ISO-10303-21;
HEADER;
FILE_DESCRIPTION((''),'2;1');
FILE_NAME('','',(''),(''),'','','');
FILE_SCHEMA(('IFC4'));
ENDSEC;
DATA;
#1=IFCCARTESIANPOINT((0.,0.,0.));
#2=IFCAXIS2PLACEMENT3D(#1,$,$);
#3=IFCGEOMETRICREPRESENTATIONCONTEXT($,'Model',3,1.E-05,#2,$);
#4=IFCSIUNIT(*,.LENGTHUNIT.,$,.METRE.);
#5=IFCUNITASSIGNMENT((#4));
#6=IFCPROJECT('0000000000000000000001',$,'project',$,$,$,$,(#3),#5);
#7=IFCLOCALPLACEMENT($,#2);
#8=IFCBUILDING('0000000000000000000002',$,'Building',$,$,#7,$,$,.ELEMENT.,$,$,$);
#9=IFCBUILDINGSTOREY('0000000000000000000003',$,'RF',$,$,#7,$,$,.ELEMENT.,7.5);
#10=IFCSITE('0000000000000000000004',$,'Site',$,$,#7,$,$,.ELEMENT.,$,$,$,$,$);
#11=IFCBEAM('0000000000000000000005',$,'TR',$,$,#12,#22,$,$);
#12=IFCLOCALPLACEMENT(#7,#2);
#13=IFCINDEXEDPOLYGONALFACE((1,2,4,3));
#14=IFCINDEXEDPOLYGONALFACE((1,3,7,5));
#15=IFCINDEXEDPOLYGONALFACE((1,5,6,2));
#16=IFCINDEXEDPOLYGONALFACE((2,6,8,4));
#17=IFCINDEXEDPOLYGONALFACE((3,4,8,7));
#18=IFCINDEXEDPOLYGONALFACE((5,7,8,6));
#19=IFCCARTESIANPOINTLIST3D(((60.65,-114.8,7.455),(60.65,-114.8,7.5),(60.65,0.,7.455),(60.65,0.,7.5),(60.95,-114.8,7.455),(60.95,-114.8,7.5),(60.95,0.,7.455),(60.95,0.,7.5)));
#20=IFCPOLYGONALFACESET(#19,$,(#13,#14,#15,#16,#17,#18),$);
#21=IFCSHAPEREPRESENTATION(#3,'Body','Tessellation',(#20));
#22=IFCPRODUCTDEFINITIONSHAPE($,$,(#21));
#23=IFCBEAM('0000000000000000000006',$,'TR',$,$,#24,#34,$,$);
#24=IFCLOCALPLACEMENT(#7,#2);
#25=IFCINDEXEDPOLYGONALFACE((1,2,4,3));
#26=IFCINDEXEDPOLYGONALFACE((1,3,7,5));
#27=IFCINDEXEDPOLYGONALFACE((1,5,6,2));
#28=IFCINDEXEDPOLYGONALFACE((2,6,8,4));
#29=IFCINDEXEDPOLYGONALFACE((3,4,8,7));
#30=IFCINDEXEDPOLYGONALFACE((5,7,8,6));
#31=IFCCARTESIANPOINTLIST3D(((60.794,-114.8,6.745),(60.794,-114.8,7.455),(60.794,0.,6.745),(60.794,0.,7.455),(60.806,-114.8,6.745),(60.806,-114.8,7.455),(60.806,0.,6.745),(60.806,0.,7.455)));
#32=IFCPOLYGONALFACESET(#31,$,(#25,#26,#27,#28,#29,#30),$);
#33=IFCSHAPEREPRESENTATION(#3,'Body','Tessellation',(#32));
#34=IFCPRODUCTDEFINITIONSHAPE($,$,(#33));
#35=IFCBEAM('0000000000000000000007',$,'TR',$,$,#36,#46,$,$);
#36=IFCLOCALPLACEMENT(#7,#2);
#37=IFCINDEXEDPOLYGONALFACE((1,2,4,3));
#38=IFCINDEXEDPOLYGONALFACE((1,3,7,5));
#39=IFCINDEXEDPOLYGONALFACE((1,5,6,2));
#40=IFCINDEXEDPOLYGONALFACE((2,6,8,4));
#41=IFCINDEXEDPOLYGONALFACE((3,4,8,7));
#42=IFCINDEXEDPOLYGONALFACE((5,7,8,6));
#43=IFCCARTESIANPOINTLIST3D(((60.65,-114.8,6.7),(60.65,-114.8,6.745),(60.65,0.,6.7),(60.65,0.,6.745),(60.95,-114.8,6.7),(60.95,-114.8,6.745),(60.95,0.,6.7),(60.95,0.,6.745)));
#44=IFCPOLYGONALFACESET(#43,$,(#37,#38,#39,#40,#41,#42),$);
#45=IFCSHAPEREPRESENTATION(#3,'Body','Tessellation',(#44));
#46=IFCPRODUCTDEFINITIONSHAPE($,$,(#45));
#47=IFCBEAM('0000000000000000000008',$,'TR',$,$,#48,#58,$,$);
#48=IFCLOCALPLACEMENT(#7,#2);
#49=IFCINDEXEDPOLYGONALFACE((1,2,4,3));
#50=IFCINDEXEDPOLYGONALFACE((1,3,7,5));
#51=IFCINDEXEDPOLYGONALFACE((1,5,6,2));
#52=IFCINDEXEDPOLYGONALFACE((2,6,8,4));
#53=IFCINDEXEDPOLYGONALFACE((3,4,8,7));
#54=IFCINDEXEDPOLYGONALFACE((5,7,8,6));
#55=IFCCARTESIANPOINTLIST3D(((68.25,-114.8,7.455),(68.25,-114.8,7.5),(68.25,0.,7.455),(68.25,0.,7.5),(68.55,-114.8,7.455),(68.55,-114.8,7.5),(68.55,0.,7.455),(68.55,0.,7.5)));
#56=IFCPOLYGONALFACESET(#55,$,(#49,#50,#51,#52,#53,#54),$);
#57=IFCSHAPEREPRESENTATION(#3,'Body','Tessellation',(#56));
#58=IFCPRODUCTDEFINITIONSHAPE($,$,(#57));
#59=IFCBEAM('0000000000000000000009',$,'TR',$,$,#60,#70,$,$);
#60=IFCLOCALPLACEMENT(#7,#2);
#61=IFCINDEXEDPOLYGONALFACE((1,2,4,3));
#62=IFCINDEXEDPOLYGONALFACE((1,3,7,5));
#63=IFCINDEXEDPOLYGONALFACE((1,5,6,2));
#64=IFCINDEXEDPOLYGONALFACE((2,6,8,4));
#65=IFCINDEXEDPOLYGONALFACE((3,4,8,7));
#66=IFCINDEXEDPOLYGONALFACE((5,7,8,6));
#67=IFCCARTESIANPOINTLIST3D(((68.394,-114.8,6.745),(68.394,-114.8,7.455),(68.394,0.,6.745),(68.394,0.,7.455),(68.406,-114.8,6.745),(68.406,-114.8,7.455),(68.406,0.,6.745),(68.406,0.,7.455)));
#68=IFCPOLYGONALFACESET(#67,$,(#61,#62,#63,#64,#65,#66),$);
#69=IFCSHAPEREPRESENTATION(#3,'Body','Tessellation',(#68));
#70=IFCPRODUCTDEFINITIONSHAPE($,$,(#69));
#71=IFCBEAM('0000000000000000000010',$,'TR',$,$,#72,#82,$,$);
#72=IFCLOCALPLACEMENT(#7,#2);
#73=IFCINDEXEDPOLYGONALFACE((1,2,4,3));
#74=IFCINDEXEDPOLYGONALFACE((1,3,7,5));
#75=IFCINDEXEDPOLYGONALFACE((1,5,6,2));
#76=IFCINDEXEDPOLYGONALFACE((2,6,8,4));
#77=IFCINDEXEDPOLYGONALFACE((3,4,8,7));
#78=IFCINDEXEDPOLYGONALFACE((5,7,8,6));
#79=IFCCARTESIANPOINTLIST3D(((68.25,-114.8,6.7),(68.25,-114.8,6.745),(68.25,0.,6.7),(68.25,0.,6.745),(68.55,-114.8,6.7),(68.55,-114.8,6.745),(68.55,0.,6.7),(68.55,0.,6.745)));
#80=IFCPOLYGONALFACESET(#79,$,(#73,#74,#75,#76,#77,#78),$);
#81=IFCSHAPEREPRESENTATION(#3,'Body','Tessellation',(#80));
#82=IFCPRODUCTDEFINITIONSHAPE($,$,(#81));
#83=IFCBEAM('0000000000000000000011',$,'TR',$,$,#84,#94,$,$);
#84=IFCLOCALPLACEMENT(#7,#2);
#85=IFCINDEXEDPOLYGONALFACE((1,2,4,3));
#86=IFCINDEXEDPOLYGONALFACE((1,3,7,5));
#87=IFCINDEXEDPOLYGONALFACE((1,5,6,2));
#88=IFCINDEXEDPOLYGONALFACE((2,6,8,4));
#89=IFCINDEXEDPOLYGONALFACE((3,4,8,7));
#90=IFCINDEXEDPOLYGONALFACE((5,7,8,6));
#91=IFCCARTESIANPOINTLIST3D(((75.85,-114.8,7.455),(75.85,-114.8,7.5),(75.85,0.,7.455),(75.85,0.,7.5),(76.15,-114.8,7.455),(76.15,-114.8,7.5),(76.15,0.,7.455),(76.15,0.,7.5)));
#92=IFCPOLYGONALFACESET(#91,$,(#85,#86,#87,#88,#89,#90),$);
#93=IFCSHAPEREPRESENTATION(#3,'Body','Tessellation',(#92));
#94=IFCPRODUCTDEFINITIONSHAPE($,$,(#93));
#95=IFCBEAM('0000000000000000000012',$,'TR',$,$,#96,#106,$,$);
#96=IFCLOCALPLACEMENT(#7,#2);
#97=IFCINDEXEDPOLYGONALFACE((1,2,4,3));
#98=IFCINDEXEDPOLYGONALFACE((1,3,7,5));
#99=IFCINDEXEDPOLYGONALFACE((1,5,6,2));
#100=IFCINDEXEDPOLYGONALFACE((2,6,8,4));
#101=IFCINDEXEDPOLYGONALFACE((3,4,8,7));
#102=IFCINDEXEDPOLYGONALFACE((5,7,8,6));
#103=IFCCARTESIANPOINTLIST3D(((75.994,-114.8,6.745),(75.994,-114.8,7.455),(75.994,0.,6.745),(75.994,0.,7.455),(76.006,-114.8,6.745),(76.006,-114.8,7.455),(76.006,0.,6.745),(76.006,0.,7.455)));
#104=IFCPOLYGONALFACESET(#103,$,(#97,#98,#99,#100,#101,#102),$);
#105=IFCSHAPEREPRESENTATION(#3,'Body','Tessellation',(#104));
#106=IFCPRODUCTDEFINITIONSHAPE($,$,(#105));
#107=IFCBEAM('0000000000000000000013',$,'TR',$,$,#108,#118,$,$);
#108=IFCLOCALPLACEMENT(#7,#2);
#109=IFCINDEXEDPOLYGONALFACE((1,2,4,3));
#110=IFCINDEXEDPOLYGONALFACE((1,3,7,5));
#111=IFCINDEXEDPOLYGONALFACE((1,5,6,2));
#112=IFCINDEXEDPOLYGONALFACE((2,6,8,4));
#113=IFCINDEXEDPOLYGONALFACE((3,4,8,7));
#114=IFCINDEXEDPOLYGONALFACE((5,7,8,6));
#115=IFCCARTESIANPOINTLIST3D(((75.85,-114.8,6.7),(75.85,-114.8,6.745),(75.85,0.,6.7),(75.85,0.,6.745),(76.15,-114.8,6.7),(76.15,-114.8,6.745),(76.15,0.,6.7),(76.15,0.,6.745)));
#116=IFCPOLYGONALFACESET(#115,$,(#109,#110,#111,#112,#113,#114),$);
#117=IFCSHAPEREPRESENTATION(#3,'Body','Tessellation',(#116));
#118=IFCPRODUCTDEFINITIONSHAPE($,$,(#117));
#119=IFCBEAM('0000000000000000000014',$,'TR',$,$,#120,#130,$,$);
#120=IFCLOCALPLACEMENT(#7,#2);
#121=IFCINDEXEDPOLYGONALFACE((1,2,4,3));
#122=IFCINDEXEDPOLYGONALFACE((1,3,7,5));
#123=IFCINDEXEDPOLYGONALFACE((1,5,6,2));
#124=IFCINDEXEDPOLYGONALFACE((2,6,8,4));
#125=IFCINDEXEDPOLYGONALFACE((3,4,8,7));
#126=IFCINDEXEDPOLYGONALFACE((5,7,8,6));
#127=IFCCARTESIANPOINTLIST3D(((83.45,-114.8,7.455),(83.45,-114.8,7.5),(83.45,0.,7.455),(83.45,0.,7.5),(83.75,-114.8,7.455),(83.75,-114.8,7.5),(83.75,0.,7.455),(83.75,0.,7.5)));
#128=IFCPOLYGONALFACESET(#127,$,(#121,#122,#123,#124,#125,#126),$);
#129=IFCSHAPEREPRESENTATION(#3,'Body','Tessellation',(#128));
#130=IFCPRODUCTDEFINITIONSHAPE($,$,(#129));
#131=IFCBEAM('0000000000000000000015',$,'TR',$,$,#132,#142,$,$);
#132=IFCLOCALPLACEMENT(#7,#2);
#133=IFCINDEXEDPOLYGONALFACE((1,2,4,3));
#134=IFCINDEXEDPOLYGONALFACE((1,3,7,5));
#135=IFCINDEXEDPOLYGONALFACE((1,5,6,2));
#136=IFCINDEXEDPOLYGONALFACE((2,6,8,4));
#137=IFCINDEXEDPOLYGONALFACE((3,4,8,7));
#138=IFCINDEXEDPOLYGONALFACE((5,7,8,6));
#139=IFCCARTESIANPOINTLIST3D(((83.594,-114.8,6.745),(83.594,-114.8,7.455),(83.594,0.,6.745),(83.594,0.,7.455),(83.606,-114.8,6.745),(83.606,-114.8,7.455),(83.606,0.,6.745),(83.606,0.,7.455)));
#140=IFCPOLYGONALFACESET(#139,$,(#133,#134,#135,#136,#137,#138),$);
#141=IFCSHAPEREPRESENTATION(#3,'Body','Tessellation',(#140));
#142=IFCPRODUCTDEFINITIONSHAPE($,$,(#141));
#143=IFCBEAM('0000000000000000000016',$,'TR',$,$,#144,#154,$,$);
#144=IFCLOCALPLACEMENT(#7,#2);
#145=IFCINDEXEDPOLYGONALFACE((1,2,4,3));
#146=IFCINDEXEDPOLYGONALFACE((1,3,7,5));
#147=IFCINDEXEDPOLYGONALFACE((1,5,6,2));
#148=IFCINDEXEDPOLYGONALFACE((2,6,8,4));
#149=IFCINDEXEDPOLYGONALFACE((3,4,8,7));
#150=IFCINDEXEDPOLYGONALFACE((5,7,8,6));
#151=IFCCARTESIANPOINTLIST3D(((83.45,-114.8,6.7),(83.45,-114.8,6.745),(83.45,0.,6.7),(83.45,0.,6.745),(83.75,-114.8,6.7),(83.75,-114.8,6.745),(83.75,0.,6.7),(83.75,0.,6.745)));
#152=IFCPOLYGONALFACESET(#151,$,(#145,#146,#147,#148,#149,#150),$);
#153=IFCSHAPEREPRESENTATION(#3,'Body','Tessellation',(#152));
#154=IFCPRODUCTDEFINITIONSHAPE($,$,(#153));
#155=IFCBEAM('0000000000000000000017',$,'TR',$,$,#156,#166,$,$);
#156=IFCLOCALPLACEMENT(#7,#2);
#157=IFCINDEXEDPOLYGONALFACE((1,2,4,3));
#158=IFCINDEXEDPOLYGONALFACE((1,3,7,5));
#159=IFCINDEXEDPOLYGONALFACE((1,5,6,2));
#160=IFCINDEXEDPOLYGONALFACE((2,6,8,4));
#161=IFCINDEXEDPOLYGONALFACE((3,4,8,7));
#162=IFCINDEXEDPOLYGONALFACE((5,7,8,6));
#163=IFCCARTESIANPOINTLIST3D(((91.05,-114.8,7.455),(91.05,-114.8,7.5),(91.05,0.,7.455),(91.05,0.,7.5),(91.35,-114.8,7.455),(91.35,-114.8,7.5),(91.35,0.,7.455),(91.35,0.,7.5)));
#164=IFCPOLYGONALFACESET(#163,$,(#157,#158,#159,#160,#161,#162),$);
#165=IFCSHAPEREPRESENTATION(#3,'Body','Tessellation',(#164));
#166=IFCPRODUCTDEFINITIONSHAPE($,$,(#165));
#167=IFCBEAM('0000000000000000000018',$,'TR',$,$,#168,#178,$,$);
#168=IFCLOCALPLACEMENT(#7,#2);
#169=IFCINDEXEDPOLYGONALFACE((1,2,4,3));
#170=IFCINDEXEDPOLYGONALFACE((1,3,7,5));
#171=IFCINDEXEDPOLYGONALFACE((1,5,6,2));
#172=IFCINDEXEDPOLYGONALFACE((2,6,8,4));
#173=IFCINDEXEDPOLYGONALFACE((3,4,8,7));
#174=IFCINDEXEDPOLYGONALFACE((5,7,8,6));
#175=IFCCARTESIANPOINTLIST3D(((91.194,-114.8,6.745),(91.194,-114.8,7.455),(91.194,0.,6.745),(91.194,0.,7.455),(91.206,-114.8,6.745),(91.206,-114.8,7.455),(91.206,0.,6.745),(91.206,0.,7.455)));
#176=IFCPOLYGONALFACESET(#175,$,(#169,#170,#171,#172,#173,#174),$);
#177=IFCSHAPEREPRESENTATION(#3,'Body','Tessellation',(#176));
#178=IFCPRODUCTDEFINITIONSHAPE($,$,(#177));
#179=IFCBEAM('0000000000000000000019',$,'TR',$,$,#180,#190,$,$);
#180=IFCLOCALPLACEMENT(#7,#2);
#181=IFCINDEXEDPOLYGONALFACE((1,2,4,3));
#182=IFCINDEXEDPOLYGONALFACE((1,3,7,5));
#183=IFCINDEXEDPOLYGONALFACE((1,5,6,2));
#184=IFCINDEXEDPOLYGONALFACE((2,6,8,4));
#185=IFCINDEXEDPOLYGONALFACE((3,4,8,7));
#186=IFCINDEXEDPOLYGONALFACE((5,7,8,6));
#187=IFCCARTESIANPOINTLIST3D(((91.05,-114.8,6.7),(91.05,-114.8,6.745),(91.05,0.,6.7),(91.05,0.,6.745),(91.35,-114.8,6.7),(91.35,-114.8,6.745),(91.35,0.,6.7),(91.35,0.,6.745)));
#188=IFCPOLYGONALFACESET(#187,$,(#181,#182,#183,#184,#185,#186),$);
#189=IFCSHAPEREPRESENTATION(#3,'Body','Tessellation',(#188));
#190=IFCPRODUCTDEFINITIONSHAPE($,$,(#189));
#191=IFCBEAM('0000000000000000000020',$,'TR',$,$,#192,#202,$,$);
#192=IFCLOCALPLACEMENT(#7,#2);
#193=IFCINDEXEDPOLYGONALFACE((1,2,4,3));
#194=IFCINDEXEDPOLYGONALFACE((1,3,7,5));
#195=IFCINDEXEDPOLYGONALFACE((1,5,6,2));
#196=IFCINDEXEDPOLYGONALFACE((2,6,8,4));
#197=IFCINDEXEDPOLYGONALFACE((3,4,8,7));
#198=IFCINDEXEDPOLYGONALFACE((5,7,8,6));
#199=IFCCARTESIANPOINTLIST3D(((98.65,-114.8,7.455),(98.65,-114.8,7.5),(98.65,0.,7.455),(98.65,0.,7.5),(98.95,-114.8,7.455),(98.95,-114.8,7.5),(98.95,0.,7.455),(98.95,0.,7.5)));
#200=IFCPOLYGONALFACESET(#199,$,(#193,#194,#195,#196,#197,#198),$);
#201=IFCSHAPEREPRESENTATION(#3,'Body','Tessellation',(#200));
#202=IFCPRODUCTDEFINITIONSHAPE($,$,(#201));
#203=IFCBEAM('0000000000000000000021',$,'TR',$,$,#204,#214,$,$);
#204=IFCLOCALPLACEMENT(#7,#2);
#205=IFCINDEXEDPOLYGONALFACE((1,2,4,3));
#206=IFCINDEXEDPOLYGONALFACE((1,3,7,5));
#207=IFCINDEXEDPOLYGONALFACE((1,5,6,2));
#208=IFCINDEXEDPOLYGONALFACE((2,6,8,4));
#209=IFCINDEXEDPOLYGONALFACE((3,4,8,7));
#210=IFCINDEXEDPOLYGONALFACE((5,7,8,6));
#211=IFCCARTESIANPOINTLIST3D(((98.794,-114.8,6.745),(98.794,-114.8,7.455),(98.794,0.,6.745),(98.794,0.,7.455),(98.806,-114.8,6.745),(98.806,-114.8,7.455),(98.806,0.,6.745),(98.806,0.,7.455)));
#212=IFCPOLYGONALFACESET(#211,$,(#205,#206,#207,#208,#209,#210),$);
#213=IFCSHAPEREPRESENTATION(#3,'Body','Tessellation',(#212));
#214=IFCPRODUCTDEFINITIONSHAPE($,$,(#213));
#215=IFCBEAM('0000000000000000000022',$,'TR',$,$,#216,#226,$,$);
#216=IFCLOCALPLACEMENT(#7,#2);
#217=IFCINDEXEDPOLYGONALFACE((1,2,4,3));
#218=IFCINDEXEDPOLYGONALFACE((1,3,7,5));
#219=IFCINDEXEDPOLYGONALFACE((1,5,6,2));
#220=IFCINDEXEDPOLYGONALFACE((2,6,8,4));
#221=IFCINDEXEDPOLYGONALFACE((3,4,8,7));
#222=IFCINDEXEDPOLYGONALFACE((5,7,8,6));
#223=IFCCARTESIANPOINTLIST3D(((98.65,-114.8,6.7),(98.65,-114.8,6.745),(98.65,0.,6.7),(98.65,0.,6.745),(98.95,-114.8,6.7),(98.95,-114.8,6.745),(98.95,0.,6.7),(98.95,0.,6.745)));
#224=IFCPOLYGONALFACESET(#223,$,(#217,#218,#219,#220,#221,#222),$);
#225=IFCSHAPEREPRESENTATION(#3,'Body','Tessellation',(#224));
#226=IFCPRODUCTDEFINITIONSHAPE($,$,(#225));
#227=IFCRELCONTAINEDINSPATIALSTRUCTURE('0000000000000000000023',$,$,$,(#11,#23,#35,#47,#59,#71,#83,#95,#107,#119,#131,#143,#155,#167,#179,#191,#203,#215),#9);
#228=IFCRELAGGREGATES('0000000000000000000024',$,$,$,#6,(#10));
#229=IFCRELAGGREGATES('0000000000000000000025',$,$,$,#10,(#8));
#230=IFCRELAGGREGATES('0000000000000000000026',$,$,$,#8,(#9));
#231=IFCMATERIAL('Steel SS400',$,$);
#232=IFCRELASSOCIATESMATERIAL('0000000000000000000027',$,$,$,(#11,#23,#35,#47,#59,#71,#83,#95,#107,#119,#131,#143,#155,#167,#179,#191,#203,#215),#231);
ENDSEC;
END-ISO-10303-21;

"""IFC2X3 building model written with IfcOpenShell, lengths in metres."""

from ifc_helpers import new_model, si_unit, frame, origin, origin_2d, place, context, project, spatial, rectangle, extrude, material, element, save


model = new_model("IFC2X3")

# Units and contexts
model_context = context("Model", 3, precision=1e-05, world=origin())
ifc_project = project(units=[si_unit("LENGTHUNIT", "METRE")], contexts=[model_context])

# Site, building, storey
placement = place(None, origin())
site = spatial("IfcSite", under=ifc_project, at=placement, Name="Site", CompositionType="ELEMENT")
building = spatial("IfcBuilding", under=site, at=placement, Name="Building", CompositionType="ELEMENT")
storey = spatial("IfcBuildingStorey", under=building, at=placement, Name="RF", CompositionType="ELEMENT", Elevation=7.5)

# Beams
ifc_material = material(Name="Steel SS400")
beam_1_placement = place(None, frame((60.8, -57.4, 7.455)))
element("IfcBeam", 1, at=beam_1_placement, inside=storey, material=ifc_material, Name="TR", context=model_context, shape_type="SweptSolid", body=[
    extrude(rectangle(XDim=0.3, YDim=114.8, at=origin_2d()), origin(), (0.0, 0.0, 1.0), 0.045),
])
beam_2_placement = place(None, frame((60.8, -57.4, 6.745)))
element("IfcBeam", 2, at=beam_2_placement, inside=storey, material=ifc_material, Name="TR", context=model_context, shape_type="SweptSolid", body=[
    extrude(rectangle(XDim=0.012, YDim=114.8, at=origin_2d()), origin(), (0.0, 0.0, 1.0), 0.71),
])
for number, where, name in (
    (3, (60.8, -57.4, 6.7), "TR"),
    (4, (68.4, -57.4, 7.455), "TR"),
):
    element("IfcBeam", number, at=place(None, frame(where)), inside=storey, material=ifc_material, Name=name, context=model_context, shape_type="SweptSolid", body=[
        extrude(rectangle(XDim=0.3, YDim=114.8, at=origin_2d()), origin(), (0.0, 0.0, 1.0), 0.045),
    ])
beam_3_placement = place(None, frame((68.4, -57.4, 6.745)))
element("IfcBeam", 5, at=beam_3_placement, inside=storey, material=ifc_material, Name="TR", context=model_context, shape_type="SweptSolid", body=[
    extrude(rectangle(XDim=0.012, YDim=114.8, at=origin_2d()), origin(), (0.0, 0.0, 1.0), 0.71),
])
for number, where, name in (
    (6, (68.4, -57.4, 6.7), "TR"),
    (7, (76.0, -57.4, 7.455), "TR"),
):
    element("IfcBeam", number, at=place(None, frame(where)), inside=storey, material=ifc_material, Name=name, context=model_context, shape_type="SweptSolid", body=[
        extrude(rectangle(XDim=0.3, YDim=114.8, at=origin_2d()), origin(), (0.0, 0.0, 1.0), 0.045),
    ])
beam_4_placement = place(None, frame((76.0, -57.4, 6.745)))
element("IfcBeam", 8, at=beam_4_placement, inside=storey, material=ifc_material, Name="TR", context=model_context, shape_type="SweptSolid", body=[
    extrude(rectangle(XDim=0.012, YDim=114.8, at=origin_2d()), origin(), (0.0, 0.0, 1.0), 0.71),
])
for number, where, name in (
    (9, (76.0, -57.4, 6.7), "TR"),
    (10, (83.6, -57.4, 7.455), "TR"),
):
    element("IfcBeam", number, at=place(None, frame(where)), inside=storey, material=ifc_material, Name=name, context=model_context, shape_type="SweptSolid", body=[
        extrude(rectangle(XDim=0.3, YDim=114.8, at=origin_2d()), origin(), (0.0, 0.0, 1.0), 0.045),
    ])
beam_5_placement = place(None, frame((83.6, -57.4, 6.745)))
element("IfcBeam", 11, at=beam_5_placement, inside=storey, material=ifc_material, Name="TR", context=model_context, shape_type="SweptSolid", body=[
    extrude(rectangle(XDim=0.012, YDim=114.8, at=origin_2d()), origin(), (0.0, 0.0, 1.0), 0.71),
])
for number, where, name in (
    (12, (83.6, -57.4, 6.7), "TR"),
    (13, (91.2, -57.4, 7.455), "TR"),
):
    element("IfcBeam", number, at=place(None, frame(where)), inside=storey, material=ifc_material, Name=name, context=model_context, shape_type="SweptSolid", body=[
        extrude(rectangle(XDim=0.3, YDim=114.8, at=origin_2d()), origin(), (0.0, 0.0, 1.0), 0.045),
    ])
beam_6_placement = place(None, frame((91.2, -57.4, 6.745)))
element("IfcBeam", 14, at=beam_6_placement, inside=storey, material=ifc_material, Name="TR", context=model_context, shape_type="SweptSolid", body=[
    extrude(rectangle(XDim=0.012, YDim=114.8, at=origin_2d()), origin(), (0.0, 0.0, 1.0), 0.71),
])
for number, where, name in (
    (15, (91.2, -57.4, 6.7), "TR"),
    (16, (98.8, -57.4, 7.455), "TR"),
):
    element("IfcBeam", number, at=place(None, frame(where)), inside=storey, material=ifc_material, Name=name, context=model_context, shape_type="SweptSolid", body=[
        extrude(rectangle(XDim=0.3, YDim=114.8, at=origin_2d()), origin(), (0.0, 0.0, 1.0), 0.045),
    ])
beam_7_placement = place(None, frame((98.8, -57.4, 6.745)))
element("IfcBeam", 17, at=beam_7_placement, inside=storey, material=ifc_material, Name="TR", context=model_context, shape_type="SweptSolid", body=[
    extrude(rectangle(XDim=0.012, YDim=114.8, at=origin_2d()), origin(), (0.0, 0.0, 1.0), 0.71),
])
beam_8_placement = place(None, frame((98.8, -57.4, 6.7)))
element("IfcBeam", 18, at=beam_8_placement, inside=storey, material=ifc_material, Name="TR", context=model_context, shape_type="SweptSolid", body=[
    extrude(rectangle(XDim=0.3, YDim=114.8, at=origin_2d()), origin(), (0.0, 0.0, 1.0), 0.045),
])

save(model, "model.ifc")
